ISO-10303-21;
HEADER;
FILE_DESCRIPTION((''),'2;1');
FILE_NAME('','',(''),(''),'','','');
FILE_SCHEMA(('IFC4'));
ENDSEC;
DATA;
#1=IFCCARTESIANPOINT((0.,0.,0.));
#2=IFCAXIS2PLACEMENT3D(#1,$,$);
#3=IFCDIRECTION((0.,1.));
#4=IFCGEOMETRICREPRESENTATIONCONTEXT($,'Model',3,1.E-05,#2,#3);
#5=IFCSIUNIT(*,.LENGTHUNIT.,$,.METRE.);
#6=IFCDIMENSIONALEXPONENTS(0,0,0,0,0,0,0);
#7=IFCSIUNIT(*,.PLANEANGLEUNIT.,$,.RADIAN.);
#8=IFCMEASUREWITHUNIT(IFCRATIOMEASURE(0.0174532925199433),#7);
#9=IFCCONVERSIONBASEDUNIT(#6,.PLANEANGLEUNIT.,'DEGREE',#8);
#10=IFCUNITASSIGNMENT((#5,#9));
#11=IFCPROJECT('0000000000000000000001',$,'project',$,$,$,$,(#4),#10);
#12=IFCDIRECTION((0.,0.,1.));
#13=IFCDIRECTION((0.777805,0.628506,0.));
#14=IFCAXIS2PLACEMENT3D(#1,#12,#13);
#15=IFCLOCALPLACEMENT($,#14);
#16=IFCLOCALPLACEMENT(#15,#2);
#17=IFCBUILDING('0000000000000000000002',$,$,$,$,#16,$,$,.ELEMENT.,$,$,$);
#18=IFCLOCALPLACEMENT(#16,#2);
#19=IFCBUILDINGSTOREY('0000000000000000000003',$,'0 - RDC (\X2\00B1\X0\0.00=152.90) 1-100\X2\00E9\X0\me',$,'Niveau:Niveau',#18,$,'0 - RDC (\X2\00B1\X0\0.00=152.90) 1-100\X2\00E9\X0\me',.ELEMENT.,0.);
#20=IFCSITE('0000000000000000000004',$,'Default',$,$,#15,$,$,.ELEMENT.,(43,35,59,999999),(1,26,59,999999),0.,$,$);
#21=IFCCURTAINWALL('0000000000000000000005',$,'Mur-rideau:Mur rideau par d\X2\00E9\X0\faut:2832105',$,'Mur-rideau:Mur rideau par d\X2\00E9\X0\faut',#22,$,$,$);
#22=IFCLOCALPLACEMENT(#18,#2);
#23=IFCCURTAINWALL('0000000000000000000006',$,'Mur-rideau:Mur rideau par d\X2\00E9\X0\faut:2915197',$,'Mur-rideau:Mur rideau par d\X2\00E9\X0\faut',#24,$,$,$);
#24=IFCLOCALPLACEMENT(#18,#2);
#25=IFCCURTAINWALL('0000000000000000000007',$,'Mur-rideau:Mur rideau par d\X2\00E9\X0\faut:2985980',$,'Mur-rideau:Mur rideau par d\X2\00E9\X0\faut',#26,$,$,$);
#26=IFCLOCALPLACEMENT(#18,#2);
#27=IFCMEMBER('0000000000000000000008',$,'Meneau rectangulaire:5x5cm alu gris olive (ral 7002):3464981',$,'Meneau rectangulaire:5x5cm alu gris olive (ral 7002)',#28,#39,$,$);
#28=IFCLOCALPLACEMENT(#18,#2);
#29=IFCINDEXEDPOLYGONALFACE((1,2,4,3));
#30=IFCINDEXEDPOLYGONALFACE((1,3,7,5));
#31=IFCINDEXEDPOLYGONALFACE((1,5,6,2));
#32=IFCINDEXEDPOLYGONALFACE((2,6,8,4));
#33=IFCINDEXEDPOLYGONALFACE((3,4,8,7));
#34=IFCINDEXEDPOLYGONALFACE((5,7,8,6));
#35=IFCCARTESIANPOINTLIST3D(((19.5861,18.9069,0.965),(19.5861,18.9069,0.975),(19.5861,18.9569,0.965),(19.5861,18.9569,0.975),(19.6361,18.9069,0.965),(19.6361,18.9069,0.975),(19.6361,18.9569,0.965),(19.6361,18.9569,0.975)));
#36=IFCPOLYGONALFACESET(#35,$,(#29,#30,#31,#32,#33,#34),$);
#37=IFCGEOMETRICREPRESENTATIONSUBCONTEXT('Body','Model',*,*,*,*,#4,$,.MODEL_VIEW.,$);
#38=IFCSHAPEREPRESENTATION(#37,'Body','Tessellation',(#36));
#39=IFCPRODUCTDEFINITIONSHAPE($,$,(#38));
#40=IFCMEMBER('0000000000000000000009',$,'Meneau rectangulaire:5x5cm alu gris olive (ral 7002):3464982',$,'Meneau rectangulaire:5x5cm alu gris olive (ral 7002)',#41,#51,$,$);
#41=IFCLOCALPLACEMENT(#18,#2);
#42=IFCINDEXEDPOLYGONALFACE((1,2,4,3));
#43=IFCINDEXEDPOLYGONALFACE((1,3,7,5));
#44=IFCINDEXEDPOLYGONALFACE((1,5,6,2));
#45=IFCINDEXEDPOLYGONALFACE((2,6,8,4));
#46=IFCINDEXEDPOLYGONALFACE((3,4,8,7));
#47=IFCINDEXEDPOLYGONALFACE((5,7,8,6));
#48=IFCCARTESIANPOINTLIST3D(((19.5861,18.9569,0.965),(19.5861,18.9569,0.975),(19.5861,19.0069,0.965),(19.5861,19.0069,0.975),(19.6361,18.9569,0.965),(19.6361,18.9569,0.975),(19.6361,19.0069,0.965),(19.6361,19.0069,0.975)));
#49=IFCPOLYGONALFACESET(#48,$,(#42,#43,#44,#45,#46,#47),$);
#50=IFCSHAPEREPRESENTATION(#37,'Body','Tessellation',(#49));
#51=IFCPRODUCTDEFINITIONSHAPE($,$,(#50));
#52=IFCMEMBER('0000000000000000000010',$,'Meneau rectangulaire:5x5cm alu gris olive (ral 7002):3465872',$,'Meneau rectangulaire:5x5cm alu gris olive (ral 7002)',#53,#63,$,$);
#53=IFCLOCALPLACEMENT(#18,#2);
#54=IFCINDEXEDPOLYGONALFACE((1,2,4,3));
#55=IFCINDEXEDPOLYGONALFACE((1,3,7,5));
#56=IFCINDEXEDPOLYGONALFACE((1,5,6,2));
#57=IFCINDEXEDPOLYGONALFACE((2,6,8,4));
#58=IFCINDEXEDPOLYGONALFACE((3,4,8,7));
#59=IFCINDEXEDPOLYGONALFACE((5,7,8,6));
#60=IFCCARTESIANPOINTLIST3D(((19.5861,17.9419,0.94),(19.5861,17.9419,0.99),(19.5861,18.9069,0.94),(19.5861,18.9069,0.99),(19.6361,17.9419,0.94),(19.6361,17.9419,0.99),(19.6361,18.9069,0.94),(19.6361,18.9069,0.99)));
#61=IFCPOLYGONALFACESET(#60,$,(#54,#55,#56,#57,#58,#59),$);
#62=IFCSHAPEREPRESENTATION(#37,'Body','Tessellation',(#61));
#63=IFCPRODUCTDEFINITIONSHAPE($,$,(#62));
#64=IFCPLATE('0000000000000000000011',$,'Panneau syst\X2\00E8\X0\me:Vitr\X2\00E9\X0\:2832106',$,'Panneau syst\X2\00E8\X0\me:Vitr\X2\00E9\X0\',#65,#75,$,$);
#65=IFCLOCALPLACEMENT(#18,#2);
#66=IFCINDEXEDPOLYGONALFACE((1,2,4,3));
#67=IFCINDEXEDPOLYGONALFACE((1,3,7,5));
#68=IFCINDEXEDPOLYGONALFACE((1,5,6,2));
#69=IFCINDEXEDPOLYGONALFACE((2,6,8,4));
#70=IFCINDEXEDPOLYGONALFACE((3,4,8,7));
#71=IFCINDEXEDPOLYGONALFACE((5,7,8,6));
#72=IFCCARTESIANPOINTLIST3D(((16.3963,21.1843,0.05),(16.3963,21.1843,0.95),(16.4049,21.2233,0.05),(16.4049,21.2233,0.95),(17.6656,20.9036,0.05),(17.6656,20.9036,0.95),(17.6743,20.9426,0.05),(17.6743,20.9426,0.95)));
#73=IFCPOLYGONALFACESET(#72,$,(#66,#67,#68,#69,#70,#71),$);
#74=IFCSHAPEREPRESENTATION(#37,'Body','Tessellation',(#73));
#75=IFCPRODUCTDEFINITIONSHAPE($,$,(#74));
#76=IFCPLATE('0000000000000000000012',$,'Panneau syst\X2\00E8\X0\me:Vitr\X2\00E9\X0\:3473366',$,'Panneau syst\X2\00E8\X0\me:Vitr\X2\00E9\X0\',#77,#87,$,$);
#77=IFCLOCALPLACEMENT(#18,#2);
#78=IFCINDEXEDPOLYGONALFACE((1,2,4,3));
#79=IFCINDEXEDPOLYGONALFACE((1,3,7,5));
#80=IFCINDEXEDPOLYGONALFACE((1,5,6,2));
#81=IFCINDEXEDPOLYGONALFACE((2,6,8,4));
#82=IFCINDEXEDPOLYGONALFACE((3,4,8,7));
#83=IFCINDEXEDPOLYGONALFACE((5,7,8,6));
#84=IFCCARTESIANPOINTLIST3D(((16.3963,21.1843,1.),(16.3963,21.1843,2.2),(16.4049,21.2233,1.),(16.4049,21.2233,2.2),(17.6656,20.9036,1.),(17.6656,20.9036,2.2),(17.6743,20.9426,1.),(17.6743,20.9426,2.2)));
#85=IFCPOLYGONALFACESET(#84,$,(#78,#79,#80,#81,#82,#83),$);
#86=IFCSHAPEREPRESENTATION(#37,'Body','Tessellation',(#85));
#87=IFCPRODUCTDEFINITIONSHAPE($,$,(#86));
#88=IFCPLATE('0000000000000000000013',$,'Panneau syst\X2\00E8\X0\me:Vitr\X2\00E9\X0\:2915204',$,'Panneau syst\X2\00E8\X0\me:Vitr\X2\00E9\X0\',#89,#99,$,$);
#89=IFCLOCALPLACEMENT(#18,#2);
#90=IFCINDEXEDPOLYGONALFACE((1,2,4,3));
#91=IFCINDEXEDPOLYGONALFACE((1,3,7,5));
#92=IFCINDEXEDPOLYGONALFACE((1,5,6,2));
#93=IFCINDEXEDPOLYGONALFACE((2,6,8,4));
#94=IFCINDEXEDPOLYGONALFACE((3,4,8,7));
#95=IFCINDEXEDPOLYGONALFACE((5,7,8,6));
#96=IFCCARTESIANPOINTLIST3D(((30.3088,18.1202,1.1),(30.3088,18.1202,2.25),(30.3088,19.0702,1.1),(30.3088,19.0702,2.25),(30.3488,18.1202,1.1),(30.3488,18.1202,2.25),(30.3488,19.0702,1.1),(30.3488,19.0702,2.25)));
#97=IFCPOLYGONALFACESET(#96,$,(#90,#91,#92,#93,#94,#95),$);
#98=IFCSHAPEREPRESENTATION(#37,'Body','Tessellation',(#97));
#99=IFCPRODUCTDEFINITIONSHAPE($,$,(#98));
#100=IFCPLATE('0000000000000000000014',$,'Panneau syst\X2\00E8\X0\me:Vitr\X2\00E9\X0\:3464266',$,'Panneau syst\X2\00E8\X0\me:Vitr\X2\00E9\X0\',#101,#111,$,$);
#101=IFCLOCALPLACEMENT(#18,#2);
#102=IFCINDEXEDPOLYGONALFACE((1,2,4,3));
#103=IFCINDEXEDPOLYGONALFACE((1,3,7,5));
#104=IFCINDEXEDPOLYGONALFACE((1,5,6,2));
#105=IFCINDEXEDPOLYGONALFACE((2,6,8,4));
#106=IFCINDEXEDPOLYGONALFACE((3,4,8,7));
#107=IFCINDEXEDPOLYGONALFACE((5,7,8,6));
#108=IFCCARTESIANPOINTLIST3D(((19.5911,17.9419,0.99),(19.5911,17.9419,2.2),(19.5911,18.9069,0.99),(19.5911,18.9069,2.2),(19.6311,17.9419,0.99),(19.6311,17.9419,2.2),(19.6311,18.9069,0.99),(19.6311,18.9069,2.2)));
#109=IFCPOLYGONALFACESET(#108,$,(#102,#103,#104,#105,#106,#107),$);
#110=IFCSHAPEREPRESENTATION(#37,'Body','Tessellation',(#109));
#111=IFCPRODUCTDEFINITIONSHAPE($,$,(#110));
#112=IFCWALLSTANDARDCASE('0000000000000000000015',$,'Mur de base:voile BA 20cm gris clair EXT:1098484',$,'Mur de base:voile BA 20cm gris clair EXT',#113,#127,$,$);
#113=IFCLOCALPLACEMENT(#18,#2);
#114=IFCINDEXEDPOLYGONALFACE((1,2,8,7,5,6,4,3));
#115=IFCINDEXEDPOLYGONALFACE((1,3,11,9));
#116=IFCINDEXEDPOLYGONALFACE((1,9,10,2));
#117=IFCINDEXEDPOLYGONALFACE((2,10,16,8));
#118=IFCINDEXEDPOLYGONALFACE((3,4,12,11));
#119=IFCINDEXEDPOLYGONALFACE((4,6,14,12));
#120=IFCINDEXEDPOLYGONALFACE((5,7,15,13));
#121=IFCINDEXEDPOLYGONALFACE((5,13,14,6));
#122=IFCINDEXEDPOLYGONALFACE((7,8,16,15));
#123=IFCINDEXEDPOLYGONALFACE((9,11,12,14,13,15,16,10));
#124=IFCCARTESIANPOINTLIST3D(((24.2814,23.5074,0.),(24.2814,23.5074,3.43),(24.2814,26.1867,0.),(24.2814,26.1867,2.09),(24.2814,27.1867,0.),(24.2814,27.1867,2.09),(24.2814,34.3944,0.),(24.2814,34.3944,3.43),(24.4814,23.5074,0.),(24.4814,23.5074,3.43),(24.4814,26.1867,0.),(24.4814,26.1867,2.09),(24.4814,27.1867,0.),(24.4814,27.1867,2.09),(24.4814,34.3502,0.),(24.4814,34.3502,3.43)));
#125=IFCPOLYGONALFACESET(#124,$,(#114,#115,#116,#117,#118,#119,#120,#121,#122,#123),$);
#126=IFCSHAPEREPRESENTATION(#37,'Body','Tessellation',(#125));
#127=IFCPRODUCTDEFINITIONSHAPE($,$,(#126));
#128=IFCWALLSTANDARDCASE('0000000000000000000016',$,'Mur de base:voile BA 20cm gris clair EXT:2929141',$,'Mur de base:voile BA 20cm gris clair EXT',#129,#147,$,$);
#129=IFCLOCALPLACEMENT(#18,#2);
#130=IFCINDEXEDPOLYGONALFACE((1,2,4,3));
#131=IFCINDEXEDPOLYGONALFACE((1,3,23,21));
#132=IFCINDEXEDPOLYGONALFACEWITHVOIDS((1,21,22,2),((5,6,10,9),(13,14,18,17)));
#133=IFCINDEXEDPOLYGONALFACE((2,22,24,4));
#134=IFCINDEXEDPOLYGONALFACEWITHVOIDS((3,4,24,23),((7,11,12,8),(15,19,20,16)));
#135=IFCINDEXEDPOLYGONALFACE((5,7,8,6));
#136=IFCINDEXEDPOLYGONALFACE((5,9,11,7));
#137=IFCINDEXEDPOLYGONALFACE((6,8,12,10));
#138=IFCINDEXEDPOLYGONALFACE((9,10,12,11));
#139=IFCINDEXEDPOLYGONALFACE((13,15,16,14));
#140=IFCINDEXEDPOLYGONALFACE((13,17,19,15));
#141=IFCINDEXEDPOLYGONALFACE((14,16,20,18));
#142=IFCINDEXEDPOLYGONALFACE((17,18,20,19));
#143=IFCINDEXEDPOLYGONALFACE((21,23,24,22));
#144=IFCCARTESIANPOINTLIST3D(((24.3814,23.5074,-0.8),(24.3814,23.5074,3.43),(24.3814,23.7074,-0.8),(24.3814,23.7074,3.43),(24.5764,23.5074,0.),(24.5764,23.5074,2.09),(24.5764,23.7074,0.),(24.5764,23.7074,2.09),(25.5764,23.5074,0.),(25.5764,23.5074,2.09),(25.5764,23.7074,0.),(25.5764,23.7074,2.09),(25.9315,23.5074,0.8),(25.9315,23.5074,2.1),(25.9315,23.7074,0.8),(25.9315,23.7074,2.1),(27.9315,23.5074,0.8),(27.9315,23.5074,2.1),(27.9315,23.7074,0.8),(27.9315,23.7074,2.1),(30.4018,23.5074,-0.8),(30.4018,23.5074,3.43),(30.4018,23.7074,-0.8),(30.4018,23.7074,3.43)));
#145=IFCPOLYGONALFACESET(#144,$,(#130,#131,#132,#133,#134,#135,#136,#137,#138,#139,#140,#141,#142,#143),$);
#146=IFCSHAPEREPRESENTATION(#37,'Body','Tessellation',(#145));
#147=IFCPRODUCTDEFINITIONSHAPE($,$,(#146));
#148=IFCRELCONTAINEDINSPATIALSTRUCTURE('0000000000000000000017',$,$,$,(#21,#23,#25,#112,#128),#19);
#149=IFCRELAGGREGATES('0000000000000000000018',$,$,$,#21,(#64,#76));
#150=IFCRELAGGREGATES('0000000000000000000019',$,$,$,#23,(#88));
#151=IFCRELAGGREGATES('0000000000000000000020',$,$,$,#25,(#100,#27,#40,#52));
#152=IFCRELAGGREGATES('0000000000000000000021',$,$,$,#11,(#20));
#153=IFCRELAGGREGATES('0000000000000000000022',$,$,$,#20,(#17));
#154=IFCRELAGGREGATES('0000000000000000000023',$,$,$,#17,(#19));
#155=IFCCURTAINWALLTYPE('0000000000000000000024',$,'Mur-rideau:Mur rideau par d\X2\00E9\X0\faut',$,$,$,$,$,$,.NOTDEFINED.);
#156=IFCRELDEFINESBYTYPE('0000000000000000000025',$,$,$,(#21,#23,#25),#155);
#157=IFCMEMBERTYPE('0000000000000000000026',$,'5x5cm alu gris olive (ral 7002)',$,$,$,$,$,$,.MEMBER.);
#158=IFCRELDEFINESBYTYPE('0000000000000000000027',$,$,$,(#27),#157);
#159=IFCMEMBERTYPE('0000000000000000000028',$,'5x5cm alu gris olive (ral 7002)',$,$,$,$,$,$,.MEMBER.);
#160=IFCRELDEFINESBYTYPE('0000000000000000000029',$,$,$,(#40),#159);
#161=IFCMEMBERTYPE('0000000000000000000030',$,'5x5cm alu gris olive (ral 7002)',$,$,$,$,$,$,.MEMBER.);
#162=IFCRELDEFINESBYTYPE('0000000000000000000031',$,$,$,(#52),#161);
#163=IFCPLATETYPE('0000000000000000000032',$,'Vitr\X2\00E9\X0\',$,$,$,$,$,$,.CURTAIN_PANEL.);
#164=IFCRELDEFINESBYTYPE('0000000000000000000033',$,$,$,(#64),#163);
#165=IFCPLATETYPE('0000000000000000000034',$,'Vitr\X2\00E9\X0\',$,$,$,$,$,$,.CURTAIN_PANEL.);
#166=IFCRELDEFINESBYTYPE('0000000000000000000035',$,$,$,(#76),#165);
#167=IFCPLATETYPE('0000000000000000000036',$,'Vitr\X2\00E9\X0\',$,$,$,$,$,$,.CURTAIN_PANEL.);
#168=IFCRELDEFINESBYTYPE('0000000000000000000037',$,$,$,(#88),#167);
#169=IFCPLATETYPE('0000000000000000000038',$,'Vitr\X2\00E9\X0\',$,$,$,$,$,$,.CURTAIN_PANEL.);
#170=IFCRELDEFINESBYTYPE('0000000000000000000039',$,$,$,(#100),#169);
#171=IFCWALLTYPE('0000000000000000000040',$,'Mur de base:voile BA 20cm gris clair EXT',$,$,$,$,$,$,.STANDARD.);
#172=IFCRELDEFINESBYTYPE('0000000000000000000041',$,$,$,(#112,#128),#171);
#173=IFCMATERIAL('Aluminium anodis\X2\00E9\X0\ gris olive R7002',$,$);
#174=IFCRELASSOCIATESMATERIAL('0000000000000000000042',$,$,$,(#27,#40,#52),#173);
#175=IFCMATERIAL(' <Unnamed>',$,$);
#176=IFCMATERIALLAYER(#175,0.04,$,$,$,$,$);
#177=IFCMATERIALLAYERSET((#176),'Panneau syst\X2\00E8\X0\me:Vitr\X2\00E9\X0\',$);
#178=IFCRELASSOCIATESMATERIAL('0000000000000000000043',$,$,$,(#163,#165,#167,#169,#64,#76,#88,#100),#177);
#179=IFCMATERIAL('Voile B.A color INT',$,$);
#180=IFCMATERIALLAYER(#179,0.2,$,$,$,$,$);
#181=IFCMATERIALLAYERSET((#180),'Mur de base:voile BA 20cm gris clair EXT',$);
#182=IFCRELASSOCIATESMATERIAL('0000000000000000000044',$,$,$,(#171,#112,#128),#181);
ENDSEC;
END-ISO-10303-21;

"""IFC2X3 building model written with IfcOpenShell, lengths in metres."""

from ifc_helpers import new_model, entity, si_unit, converted_unit, direction, frame, frame_2d, origin, origin_2d_with_axis, place, context, subcontext, project, spatial, polyline, rectangle, outline, extrude, source, transform, mapped, material, layer, layer_set, layer_usage, type_object, type_shapes, element, aggregate, save


model = new_model("IFC2X3")

# Units and contexts
model_context = context("Model", 3, precision=1e-05, world=origin(), true_north=direction((0.0, 1.0)))
body_context = subcontext(model_context, "Body", "Model", "MODEL_VIEW")
ifc_project = project(units=[si_unit("LENGTHUNIT", "METRE"), converted_unit("PLANEANGLEUNIT", "DEGREE", entity("IfcRatioMeasure", 0.0174532925199433), si_unit("PLANEANGLEUNIT", "RADIAN"), dimensions=[0, 0, 0, 0, 0, 0, 0])], contexts=[model_context])

# Site, building, storey
site_placement = place(None, frame((0.0, 0.0, 0.0), z_axis=(0.0, 0.0, 1.0), x_axis=(0.777805, 0.628506, 0.0)))
site = spatial("IfcSite", under=ifc_project, at=site_placement, Name="Default", CompositionType="ELEMENT", RefLatitude=(43, 35, 59, 999999), RefLongitude=(1, 26, 59, 999999), RefElevation=0.0)
building_placement = place(site_placement, origin())
building = spatial("IfcBuilding", under=site, at=building_placement, CompositionType="ELEMENT")
storey_placement = place(building_placement, origin())
storey = spatial("IfcBuildingStorey", under=building, at=storey_placement, Name="0 - RDC (±0.00=152.90) 1-100éme", ObjectType="Niveau:Niveau", LongName="0 - RDC (±0.00=152.90) 1-100éme", CompositionType="ELEMENT", Elevation=0.0)

# Curtain wall
curtain_wall_type = type_object("IfcCurtainWallType", Name="Mur-rideau:Mur rideau par défaut", PredefinedType="NOTDEFINED")
curtain_wall_1_placement = place(storey_placement, origin())
curtain_wall_1 = element("IfcCurtainWall", 1, at=curtain_wall_1_placement, inside=storey, type_object=curtain_wall_type, Name="Mur-rideau:Mur rideau par défaut:2832105", ObjectType="Mur-rideau:Mur rideau par défaut")
ifc_material_1 = material(Name="Aluminium anodisé gris olive R7002")

# Curtain wall
curtain_wall_2_placement = place(storey_placement, origin())
curtain_wall_2 = element("IfcCurtainWall", 2, at=curtain_wall_2_placement, inside=storey, type_object=curtain_wall_type, Name="Mur-rideau:Mur rideau par défaut:2915197", ObjectType="Mur-rideau:Mur rideau par défaut")

# Curtain wall, members
curtain_wall_3_placement = place(storey_placement, origin())
curtain_wall_3 = element("IfcCurtainWall", 3, at=curtain_wall_3_placement, inside=storey, type_object=curtain_wall_type, Name="Mur-rideau:Mur rideau par défaut:2985980", ObjectType="Mur-rideau:Mur rideau par défaut")
member_type_1 = type_object("IfcMemberType", Name="5x5cm alu gris olive (ral 7002)", PredefinedType="MEMBER")
shared_shape_1 = source(origin(), body_context, "Body", "SweptSolid", [
    extrude(rectangle(XDim=0.05, YDim=0.05, at=origin_2d_with_axis()), frame((0.0, 0.0, -0.01), z_axis=(0.0, 0.0, 1.0), x_axis=(0.0, -1.0, 0.0)), (0.0, 0.0, 1.0), 0.01),
])
type_shapes(member_type_1, [shared_shape_1])
member_1_placement = place(storey_placement, frame((19.6111, 18.9319, 0.965), z_axis=(0.0, 0.0, -1.0), x_axis=(0.0, 1.0, 0.0)))
member_1 = element("IfcMember", 4, at=member_1_placement, type_object=member_type_1, material=ifc_material_1, Name="Meneau rectangulaire:5x5cm alu gris olive (ral 7002):3464981", ObjectType="Meneau rectangulaire:5x5cm alu gris olive (ral 7002)", context=body_context, shape_type="MappedRepresentation", body=[
    mapped(shared_shape_1, transform((0.0, 0.0, 0.0), scale=1.0)),
])
member_type_2 = type_object("IfcMemberType", Name="5x5cm alu gris olive (ral 7002)", PredefinedType="MEMBER")
shared_shape_2 = source(origin(), body_context, "Body", "SweptSolid", [
    extrude(rectangle(XDim=0.05, YDim=0.05, at=origin_2d_with_axis()), frame((-0.025, 0.0, -0.01), z_axis=(0.0, 0.0, 1.0), x_axis=(0.0, -1.0, 0.0)), (0.0, 0.0, 1.0), 0.01),
])
type_shapes(member_type_2, [shared_shape_2])
member_2_placement = place(storey_placement, frame((19.6111, 19.0069, 0.965), z_axis=(0.0, 0.0, -1.0), x_axis=(0.0, 1.0, 0.0)))
member_2 = element("IfcMember", 5, at=member_2_placement, type_object=member_type_2, material=ifc_material_1, Name="Meneau rectangulaire:5x5cm alu gris olive (ral 7002):3464982", ObjectType="Meneau rectangulaire:5x5cm alu gris olive (ral 7002)", context=body_context, shape_type="MappedRepresentation", body=[
    mapped(shared_shape_2, transform((0.0, 0.0, 0.0), scale=1.0)),
])
member_type_3 = type_object("IfcMemberType", Name="5x5cm alu gris olive (ral 7002)", PredefinedType="MEMBER")
shared_shape_3 = source(origin(), body_context, "Body", "SweptSolid", [
    extrude(rectangle(XDim=0.05, YDim=0.05, at=origin_2d_with_axis()), frame((0.0, 0.0, -0.965), z_axis=(0.0, 0.0, 1.0), x_axis=(0.0, -1.0, 0.0)), (0.0, 0.0, 1.0), 0.965),
])
type_shapes(member_type_3, [shared_shape_3])
member_3_placement = place(storey_placement, frame((19.6111, 18.9069, 0.965), z_axis=(0.0, 1.0, 0.0), x_axis=(0.0, 0.0, 1.0)))
member_3 = element("IfcMember", 6, at=member_3_placement, type_object=member_type_3, material=ifc_material_1, Name="Meneau rectangulaire:5x5cm alu gris olive (ral 7002):3465872", ObjectType="Meneau rectangulaire:5x5cm alu gris olive (ral 7002)", context=body_context, shape_type="MappedRepresentation", body=[
    mapped(shared_shape_3, transform((0.0, 0.0, 0.0), scale=1.0)),
])

# Plates
ifc_material_2 = material(Name=" <Unnamed>")
ifc_layer_1 = layer(ifc_material_2, 0.04)
ifc_layer_set_1 = layer_set([ifc_layer_1], Name="Panneau système:Vitré")
ifc_layer_usage_1 = layer_usage(ifc_layer_set_1, "AXIS3", "POSITIVE", 0.0)
plate_type_1 = type_object("IfcPlateType", Name="Vitré", PredefinedType="CURTAIN_PANEL", material=ifc_layer_set_1)
shared_shape_4 = source(origin(), body_context, "Body", "SweptSolid", [
    extrude(rectangle(XDim=0.04, YDim=1.3, at=origin_2d_with_axis()), frame((0.0, 0.0, 0.0), z_axis=(0.0, 0.0, 1.0), x_axis=(0.0, 1.0, 0.0)), (0.0, 0.0, 1.0), 0.9),
])
type_shapes(plate_type_1, [shared_shape_4])
plate_1_placement = place(curtain_wall_1_placement, frame((17.0353, 21.0634, 0.05), z_axis=(0.0, 0.0, 1.0), x_axis=(0.976415, -0.2159, 0.0)))
plate_1 = element("IfcPlate", 7, at=plate_1_placement, type_object=plate_type_1, material=ifc_layer_usage_1, Name="Panneau système:Vitré:2832106", ObjectType="Panneau système:Vitré", context=body_context, shape_type="MappedRepresentation", body=[
    mapped(shared_shape_4, transform((0.0, 0.0, 0.0), scale=1.0)),
])
ifc_layer_usage_2 = layer_usage(ifc_layer_set_1, "AXIS3", "POSITIVE", 0.0)
plate_type_2 = type_object("IfcPlateType", Name="Vitré", PredefinedType="CURTAIN_PANEL", material=ifc_layer_set_1)
shared_shape_5 = source(origin(), body_context, "Body", "SweptSolid", [
    extrude(rectangle(XDim=0.04, YDim=1.3, at=frame_2d((0.0, 0.0), x_axis=(1.0, 0.0))), frame((0.0, 0.0, 0.0), z_axis=(0.0, 0.0, 1.0), x_axis=(0.0, 1.0, 0.0)), (0.0, 0.0, 1.0), 1.2),
])
type_shapes(plate_type_2, [shared_shape_5])
plate_2_placement = place(curtain_wall_1_placement, frame((17.0353, 21.0634, 1.0), z_axis=(0.0, 0.0, 1.0), x_axis=(0.976415, -0.2159, 0.0)))
plate_2 = element("IfcPlate", 8, at=plate_2_placement, type_object=plate_type_2, material=ifc_layer_usage_2, Name="Panneau système:Vitré:3473366", ObjectType="Panneau système:Vitré", context=body_context, shape_type="MappedRepresentation", body=[
    mapped(shared_shape_5, transform((0.0, 0.0, 0.0), scale=1.0)),
])
aggregate(curtain_wall_1, [plate_1, plate_2])
ifc_layer_usage_3 = layer_usage(ifc_layer_set_1, "AXIS3", "POSITIVE", 0.0)
plate_type_3 = type_object("IfcPlateType", Name="Vitré", PredefinedType="CURTAIN_PANEL", material=ifc_layer_set_1)
shared_shape_6 = source(origin(), body_context, "Body", "SweptSolid", [
    extrude(rectangle(XDim=0.04, YDim=0.95, at=origin_2d_with_axis()), frame((0.0, 0.0, 0.0), z_axis=(0.0, 0.0, 1.0), x_axis=(0.0, 1.0, 0.0)), (0.0, 0.0, 1.0), 1.15),
])
type_shapes(plate_type_3, [shared_shape_6])
plate_3_placement = place(curtain_wall_2_placement, frame((30.3288, 18.5952, 1.1), z_axis=(0.0, 0.0, 1.0), x_axis=(0.0, -1.0, 0.0)))
plate_3 = element("IfcPlate", 9, at=plate_3_placement, type_object=plate_type_3, material=ifc_layer_usage_3, Name="Panneau système:Vitré:2915204", ObjectType="Panneau système:Vitré", context=body_context, shape_type="MappedRepresentation", body=[
    mapped(shared_shape_6, transform((0.0, 0.0, 0.0), scale=1.0)),
])
aggregate(curtain_wall_2, [plate_3])
ifc_layer_usage_4 = layer_usage(ifc_layer_set_1, "AXIS3", "POSITIVE", 0.0)
plate_type_4 = type_object("IfcPlateType", Name="Vitré", PredefinedType="CURTAIN_PANEL", material=ifc_layer_set_1)
shared_shape_7 = source(origin(), body_context, "Body", "SweptSolid", [
    extrude(rectangle(XDim=0.04, YDim=0.965, at=origin_2d_with_axis()), frame((0.0, 0.0, 0.0), z_axis=(0.0, 0.0, 1.0), x_axis=(0.0, 1.0, 0.0)), (0.0, 0.0, 1.0), 1.21),
])
type_shapes(plate_type_4, [shared_shape_7])
plate_4_placement = place(curtain_wall_3_placement, frame((19.6111, 18.4244, 0.99), z_axis=(0.0, 0.0, 1.0), x_axis=(0.0, 1.0, 0.0)))
plate_4 = element("IfcPlate", 10, at=plate_4_placement, type_object=plate_type_4, material=ifc_layer_usage_4, Name="Panneau système:Vitré:3464266", ObjectType="Panneau système:Vitré", context=body_context, shape_type="MappedRepresentation", body=[
    mapped(shared_shape_7, transform((0.0, 0.0, 0.0), scale=1.0)),
])
aggregate(curtain_wall_3, [plate_4, member_1, member_2, member_3])

# Wall, opening
ifc_material_3 = material(Name="Voile B.A color INT")
ifc_layer_2 = layer(ifc_material_3, 0.2)
ifc_layer_set_2 = layer_set([ifc_layer_2], Name="Mur de base:voile BA 20cm gris clair EXT")
ifc_layer_usage_5 = layer_usage(ifc_layer_set_2, "AXIS2", "NEGATIVE", 0.1)
wall_type_1 = type_object("IfcWallType", Name="Mur de base:voile BA 20cm gris clair EXT", PredefinedType="STANDARD", material=ifc_layer_set_2)
wall_1_placement = place(storey_placement, frame((24.3814, 23.5074, 0.0), z_axis=(0.0, 0.0, 1.0), x_axis=(0.0, 1.0, 0.0)))
wall_1 = element("IfcWallStandardCase", 11, at=wall_1_placement, inside=storey, type_object=wall_type_1, material=ifc_layer_usage_5, Name="Mur de base:voile BA 20cm gris clair EXT:1098484", ObjectType="Mur de base:voile BA 20cm gris clair EXT", context=body_context, shape_type="SweptSolid", body=[
    extrude(outline(polyline([(0.0, -0.1), (0.2, -0.1), (4.6915, -0.1), (4.7645, -0.1), (4.9645, -0.1), (7.0763, -0.1), (7.2763, -0.1), (10.8428, -0.1), (10.8871, 0.1), (7.2763, 0.1), (7.0763, 0.1), (3.9643, 0.1), (3.8643, 0.1), (0.2, 0.1), (0.0, 0.1), (0.0, -0.1)])), origin(), (0.0, 0.0, 1.0), 3.43),
])
opening_1_placement = place(wall_1_placement, frame((2.6793, -0.1, 0.0)))
element("IfcOpeningElement", 12, at=opening_1_placement, cuts=wall_1, ObjectType="Opening", context=body_context, shape_type="SweptSolid", body=[
    extrude(rectangle(XDim=2.09, YDim=1.0, at=frame_2d((1.045, 0.5), x_axis=(1.0, 0.0))), frame((0.0, 0.0, 0.0), z_axis=(0.0, 1.0, 0.0), x_axis=(0.0, 0.0, 1.0)), (0.0, 0.0, 1.0), 0.2),
])

# Wall, openings
ifc_layer_usage_6 = layer_usage(ifc_layer_set_2, "AXIS2", "NEGATIVE", 0.1)
wall_2_placement = place(storey_placement, frame((24.3814, 23.6074, -0.8)))
wall_2 = element("IfcWallStandardCase", 13, at=wall_2_placement, inside=storey, type_object=wall_type_1, material=ifc_layer_usage_6, Name="Mur de base:voile BA 20cm gris clair EXT:2929141", ObjectType="Mur de base:voile BA 20cm gris clair EXT", context=body_context, shape_type="SweptSolid", body=[
    extrude(rectangle(XDim=6.0204, YDim=0.2, at=frame_2d((3.0102, 0.0), x_axis=(-1.0, 0.0))), origin(), (0.0, 0.0, 1.0), 4.23),
])
opening_2_placement = place(wall_2_placement, origin())
element("IfcOpeningElement", 14, at=opening_2_placement, cuts=wall_2, ObjectType="Opening", context=body_context, shape_type="SweptSolid", body=[
    extrude(rectangle(XDim=1.3, YDim=2.0, at=frame_2d((0.0, 0.0), x_axis=(1.0, 0.0))), frame((2.5501, -0.1, 2.25), z_axis=(0.0, 1.0, 0.0), x_axis=(0.0, 0.0, -1.0)), (0.0, 0.0, 1.0), 0.2),
])
opening_3_placement = place(wall_2_placement, frame((0.195, -0.1, 0.8)))
element("IfcOpeningElement", 15, at=opening_3_placement, cuts=wall_2, ObjectType="Opening", context=body_context, shape_type="SweptSolid", body=[
    extrude(rectangle(XDim=2.09, YDim=1.0, at=frame_2d((1.045, 0.5), x_axis=(1.0, 0.0))), frame((0.0, 0.0, 0.0), z_axis=(0.0, 1.0, 0.0), x_axis=(0.0, 0.0, 1.0)), (0.0, 0.0, 1.0), 0.2),
])

save(model, "model.ifc")
